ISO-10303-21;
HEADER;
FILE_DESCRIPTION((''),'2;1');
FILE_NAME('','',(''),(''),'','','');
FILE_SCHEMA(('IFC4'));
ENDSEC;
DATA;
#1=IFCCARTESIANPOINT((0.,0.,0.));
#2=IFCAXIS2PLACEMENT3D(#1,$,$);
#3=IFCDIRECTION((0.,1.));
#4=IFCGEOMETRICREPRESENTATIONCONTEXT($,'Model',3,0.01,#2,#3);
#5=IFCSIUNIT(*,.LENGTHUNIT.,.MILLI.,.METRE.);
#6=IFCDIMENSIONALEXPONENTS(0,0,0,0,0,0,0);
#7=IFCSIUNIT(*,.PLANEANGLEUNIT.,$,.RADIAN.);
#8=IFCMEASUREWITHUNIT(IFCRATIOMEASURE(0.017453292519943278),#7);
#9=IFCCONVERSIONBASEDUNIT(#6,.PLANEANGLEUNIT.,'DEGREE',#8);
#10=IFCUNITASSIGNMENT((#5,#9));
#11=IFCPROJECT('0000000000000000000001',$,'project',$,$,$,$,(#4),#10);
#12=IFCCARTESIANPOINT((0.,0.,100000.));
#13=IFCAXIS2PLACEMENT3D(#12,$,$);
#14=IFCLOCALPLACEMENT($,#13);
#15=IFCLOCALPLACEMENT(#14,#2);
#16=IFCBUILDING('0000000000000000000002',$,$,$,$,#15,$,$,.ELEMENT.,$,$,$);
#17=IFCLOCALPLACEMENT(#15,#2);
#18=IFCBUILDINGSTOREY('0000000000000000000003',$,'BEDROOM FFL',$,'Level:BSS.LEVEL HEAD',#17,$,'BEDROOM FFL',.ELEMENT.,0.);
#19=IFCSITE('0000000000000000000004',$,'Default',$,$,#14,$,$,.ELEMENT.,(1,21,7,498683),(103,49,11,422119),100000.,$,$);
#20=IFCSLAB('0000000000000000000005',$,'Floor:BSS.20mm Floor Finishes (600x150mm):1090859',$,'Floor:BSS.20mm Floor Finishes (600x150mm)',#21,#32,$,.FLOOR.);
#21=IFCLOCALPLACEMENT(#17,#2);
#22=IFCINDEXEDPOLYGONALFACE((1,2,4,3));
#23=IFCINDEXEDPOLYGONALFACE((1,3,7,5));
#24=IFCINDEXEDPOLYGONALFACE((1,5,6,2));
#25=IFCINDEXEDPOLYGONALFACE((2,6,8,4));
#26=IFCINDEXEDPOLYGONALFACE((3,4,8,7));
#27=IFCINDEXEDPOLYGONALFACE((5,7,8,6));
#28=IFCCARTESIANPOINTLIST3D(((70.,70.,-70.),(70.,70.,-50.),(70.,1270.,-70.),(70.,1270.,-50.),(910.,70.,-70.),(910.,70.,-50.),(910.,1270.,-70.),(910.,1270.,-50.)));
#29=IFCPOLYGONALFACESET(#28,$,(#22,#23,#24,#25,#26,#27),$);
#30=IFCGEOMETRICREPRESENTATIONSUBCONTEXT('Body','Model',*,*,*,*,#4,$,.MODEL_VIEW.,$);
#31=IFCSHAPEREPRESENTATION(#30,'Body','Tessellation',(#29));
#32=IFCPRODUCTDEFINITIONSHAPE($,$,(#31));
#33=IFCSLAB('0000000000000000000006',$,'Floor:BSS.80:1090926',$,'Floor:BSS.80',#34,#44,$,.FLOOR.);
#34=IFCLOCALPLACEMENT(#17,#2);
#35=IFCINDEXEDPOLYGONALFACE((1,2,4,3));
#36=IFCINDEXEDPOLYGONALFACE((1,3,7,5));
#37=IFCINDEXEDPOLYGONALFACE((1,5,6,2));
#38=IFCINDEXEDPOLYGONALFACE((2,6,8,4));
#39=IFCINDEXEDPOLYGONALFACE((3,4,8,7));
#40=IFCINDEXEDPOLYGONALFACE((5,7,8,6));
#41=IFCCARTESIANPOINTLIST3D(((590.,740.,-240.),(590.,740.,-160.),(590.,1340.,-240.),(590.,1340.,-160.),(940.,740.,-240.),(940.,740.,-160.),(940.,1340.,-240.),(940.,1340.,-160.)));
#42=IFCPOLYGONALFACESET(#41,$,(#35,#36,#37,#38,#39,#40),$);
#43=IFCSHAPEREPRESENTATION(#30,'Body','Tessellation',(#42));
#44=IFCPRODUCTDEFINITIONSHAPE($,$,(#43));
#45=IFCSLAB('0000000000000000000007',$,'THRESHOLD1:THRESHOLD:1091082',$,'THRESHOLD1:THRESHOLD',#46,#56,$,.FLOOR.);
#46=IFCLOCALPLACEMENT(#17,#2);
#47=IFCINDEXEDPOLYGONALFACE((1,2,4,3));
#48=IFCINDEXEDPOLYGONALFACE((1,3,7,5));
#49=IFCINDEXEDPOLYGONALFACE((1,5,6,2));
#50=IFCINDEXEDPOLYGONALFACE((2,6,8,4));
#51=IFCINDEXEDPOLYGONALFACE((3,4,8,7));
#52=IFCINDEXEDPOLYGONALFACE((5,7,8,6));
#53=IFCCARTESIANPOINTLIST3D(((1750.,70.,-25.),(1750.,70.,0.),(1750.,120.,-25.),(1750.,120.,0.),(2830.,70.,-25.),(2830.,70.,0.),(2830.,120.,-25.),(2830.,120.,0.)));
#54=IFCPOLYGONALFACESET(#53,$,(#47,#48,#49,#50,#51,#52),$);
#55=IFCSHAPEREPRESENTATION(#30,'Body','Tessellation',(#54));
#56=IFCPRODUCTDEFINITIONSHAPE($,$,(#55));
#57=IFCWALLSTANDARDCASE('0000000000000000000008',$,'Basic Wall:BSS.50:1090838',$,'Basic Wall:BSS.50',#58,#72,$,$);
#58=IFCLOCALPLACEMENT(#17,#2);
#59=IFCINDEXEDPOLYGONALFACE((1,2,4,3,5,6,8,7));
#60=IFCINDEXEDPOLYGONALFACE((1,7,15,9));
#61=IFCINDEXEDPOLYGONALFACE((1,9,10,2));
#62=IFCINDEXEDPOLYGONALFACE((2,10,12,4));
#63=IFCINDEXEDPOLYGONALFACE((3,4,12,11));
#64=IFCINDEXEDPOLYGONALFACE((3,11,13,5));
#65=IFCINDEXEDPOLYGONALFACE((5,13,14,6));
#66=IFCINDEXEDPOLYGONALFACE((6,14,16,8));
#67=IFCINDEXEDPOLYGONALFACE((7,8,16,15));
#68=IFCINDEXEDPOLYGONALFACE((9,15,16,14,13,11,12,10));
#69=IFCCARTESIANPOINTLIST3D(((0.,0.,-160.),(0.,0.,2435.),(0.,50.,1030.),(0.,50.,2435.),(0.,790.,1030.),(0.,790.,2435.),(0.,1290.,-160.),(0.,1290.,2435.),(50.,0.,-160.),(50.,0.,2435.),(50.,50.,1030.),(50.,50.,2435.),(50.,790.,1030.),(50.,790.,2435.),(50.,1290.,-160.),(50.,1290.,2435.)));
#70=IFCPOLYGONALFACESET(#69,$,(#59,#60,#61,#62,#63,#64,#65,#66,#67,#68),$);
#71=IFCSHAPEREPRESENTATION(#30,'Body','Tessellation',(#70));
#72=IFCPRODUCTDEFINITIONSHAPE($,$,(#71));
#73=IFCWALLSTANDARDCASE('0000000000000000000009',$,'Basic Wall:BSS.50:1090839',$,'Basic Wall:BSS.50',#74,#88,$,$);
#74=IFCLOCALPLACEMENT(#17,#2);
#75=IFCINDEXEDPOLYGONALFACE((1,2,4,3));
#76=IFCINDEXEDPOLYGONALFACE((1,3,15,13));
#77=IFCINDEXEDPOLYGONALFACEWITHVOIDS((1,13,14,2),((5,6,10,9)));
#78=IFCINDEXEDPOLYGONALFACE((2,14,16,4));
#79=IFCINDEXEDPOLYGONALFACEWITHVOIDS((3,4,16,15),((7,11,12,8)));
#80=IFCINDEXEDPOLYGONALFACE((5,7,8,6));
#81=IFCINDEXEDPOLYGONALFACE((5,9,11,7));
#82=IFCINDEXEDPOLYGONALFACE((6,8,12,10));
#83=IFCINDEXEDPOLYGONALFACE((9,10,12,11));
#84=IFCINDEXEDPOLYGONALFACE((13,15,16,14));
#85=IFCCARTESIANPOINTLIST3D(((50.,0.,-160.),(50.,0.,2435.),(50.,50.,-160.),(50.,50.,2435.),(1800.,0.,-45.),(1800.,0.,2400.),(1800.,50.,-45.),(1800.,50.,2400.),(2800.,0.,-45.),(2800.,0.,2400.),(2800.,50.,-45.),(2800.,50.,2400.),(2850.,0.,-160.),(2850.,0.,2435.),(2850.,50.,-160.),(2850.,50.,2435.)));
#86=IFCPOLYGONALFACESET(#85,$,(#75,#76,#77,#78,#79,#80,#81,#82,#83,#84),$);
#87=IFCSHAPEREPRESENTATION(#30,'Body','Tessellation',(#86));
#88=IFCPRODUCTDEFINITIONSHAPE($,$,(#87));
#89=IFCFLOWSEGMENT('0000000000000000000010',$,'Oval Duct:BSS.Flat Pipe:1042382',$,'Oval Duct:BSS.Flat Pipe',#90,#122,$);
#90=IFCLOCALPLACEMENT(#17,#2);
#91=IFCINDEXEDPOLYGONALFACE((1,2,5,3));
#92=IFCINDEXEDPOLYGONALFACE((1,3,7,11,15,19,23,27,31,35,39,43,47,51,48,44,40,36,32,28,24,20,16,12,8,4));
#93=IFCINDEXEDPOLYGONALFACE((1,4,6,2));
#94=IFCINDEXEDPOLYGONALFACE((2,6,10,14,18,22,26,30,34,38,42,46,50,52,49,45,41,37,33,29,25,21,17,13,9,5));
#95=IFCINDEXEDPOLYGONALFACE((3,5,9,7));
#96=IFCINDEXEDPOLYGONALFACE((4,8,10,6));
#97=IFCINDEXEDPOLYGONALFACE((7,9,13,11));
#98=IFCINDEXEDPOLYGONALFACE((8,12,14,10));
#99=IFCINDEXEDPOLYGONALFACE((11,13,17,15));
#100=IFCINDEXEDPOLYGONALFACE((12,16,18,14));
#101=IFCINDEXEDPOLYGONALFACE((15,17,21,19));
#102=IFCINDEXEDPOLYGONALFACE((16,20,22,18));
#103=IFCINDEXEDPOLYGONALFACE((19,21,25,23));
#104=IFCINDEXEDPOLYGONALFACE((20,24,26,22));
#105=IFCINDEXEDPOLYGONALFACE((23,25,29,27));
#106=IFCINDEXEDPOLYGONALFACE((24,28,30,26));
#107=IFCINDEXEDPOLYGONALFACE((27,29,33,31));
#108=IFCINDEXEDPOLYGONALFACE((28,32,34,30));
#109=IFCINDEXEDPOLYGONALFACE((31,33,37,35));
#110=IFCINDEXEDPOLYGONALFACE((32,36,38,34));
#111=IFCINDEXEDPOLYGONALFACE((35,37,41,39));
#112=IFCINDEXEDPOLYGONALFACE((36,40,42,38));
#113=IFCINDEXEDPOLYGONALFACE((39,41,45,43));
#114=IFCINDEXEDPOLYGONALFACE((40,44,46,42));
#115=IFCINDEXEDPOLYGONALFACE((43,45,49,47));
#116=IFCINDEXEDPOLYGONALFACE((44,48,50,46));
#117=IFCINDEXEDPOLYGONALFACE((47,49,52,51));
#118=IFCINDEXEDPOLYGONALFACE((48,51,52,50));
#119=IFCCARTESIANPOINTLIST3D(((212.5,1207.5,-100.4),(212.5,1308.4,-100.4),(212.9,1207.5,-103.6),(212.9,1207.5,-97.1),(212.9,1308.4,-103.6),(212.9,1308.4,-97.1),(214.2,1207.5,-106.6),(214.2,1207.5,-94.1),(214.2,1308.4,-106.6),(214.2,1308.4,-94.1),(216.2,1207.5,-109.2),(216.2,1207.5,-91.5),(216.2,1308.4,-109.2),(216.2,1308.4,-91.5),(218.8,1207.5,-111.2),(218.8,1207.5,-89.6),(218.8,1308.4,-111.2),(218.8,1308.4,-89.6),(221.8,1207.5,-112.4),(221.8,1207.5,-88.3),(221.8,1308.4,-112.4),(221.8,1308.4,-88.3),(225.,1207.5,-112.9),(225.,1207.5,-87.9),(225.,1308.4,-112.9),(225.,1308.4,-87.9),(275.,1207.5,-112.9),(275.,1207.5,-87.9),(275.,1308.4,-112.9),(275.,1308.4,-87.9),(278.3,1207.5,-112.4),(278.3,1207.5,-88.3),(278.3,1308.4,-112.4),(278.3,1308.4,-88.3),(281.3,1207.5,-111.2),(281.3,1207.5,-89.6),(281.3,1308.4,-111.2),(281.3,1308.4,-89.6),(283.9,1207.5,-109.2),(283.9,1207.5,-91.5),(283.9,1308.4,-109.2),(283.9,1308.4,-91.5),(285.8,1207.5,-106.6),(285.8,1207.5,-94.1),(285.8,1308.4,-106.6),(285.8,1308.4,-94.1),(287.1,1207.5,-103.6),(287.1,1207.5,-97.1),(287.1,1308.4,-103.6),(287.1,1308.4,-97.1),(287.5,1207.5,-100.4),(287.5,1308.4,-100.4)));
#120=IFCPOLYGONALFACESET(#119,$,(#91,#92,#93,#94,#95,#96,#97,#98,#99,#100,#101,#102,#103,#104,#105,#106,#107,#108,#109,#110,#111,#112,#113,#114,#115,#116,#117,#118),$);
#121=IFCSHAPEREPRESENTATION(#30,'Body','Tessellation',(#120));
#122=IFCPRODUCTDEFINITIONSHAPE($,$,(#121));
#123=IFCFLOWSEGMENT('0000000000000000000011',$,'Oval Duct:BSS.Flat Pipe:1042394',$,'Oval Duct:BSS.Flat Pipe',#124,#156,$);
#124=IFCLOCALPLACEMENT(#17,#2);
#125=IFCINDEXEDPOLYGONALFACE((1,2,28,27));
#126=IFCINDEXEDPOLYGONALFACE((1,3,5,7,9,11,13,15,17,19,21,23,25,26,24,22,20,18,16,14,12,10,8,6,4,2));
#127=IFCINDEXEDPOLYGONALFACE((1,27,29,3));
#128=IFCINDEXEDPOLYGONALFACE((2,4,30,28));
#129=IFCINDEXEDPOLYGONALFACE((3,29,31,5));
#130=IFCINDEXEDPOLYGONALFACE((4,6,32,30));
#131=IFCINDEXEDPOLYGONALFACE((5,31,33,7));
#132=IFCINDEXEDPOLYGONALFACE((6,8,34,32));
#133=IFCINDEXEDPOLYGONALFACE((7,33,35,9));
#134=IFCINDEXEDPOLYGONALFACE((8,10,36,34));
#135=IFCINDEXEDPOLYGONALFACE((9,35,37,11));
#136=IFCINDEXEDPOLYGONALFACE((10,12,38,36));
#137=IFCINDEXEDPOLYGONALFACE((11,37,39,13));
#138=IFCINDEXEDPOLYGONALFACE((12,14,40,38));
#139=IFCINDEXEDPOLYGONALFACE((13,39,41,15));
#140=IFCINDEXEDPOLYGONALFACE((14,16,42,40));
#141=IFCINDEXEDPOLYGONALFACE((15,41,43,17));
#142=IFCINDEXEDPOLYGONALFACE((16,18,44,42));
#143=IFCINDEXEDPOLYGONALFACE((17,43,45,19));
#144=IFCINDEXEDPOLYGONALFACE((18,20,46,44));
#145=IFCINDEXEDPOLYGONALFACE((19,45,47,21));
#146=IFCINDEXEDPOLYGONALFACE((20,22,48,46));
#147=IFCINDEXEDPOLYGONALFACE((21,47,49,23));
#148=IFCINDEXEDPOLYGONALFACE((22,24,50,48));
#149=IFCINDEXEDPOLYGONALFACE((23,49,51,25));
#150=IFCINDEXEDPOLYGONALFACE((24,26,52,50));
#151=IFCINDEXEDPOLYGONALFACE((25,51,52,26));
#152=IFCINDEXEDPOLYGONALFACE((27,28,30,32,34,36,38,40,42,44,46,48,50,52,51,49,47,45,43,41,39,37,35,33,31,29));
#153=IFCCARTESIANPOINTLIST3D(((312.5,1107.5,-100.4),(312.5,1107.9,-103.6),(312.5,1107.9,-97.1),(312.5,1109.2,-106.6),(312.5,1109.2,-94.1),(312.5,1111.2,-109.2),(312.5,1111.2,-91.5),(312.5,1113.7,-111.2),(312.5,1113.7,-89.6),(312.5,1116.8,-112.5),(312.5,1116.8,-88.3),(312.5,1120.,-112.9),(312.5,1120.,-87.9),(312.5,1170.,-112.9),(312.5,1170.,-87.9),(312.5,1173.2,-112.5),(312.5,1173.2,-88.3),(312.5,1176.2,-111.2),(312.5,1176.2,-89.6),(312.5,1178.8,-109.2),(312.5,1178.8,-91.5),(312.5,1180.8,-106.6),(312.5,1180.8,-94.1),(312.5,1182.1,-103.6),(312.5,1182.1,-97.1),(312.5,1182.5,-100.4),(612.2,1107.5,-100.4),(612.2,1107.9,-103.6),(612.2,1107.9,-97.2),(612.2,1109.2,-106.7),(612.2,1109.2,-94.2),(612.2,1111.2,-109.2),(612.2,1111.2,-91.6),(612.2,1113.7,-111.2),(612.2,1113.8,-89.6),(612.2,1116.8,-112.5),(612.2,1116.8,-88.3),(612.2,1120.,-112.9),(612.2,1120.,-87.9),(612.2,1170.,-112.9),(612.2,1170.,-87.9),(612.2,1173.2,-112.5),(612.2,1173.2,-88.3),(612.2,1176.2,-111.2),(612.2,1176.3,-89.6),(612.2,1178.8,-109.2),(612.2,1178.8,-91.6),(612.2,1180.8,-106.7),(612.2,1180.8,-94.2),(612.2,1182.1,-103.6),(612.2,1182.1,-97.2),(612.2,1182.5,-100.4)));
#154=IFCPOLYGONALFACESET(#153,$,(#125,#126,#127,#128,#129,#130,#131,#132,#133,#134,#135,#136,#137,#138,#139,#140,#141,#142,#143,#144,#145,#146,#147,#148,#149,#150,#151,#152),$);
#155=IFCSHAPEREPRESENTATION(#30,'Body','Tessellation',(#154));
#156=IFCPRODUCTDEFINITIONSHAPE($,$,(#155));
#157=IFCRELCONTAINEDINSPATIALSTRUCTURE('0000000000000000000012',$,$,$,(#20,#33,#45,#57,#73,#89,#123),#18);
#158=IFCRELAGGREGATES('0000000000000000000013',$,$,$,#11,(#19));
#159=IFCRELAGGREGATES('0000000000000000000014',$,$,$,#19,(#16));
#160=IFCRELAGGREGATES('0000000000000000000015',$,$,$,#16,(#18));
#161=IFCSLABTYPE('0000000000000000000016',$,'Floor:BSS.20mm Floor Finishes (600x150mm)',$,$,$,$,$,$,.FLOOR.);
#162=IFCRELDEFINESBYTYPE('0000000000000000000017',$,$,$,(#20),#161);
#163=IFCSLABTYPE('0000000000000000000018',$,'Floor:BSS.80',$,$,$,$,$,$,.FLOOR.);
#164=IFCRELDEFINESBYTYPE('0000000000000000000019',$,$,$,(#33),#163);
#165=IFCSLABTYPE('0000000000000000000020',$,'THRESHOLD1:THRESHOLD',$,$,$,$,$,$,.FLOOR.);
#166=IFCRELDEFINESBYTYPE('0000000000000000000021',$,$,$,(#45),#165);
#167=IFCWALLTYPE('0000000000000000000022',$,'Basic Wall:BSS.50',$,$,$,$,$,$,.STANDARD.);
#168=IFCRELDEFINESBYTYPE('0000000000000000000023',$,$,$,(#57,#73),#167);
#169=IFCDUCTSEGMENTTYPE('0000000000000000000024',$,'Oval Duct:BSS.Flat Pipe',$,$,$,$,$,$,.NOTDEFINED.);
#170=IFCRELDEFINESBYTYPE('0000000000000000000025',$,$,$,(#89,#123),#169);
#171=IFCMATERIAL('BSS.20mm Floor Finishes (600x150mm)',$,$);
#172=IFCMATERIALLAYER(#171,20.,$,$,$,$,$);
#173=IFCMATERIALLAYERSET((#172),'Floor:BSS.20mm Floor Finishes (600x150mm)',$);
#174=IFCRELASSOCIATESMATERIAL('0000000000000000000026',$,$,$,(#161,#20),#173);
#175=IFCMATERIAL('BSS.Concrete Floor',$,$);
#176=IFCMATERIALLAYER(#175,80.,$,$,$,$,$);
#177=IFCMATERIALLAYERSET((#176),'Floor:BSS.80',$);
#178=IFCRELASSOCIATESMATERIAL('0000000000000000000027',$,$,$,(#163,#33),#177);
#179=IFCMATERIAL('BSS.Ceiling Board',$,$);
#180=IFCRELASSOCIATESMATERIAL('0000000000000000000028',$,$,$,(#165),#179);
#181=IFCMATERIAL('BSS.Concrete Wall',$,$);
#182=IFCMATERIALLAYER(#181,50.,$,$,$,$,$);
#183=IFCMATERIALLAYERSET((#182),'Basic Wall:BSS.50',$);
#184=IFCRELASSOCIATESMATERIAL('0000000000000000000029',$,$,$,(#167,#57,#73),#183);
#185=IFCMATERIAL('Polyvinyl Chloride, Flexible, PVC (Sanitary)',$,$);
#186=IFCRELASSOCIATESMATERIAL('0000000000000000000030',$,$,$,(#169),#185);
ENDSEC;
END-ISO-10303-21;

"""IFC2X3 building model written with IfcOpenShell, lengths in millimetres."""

from ifc_helpers import new_model, entity, si_unit, converted_unit, direction, frame, frame_2d, origin, origin_2d_with_axis, place, context, subcontext, project, spatial, polyline, circle_curve, parameter, trimmed, segment, composite_curve, rectangle, outline, extrude, material, layer, layer_set, layer_usage, type_object, element, save


model = new_model("IFC2X3")

# Units and contexts
model_context = context("Model", 3, precision=0.01, world=origin(), true_north=direction((0.0, 1.0)))
body_context = subcontext(model_context, "Body", "Model", "MODEL_VIEW")
ifc_project = project(units=[si_unit("LENGTHUNIT", "METRE", prefix="MILLI"), converted_unit("PLANEANGLEUNIT", "DEGREE", entity("IfcRatioMeasure", 0.017453292519943278), si_unit("PLANEANGLEUNIT", "RADIAN"), dimensions=[0, 0, 0, 0, 0, 0, 0])], contexts=[model_context])

# Site, building, storey
site_placement = place(None, frame((0.0, 0.0, 100000.0)))
site = spatial("IfcSite", under=ifc_project, at=site_placement, Name="Default", CompositionType="ELEMENT", RefLatitude=(1, 21, 7, 498683), RefLongitude=(103, 49, 11, 422119), RefElevation=100000.0)
building_placement = place(site_placement, origin())
building = spatial("IfcBuilding", under=site, at=building_placement, CompositionType="ELEMENT")
storey_placement = place(building_placement, origin())
storey = spatial("IfcBuildingStorey", under=building, at=storey_placement, Name="BEDROOM FFL", ObjectType="Level:BSS.LEVEL HEAD", LongName="BEDROOM FFL", CompositionType="ELEMENT", Elevation=0.0)

# Slabs
ifc_material_1 = material(Name="BSS.Concrete Floor")
ifc_material_2 = material(Name="BSS.20mm Floor Finishes (600x150mm)")
ifc_layer_1 = layer(ifc_material_2, 20.0)
ifc_layer_set_1 = layer_set([ifc_layer_1], Name="Floor:BSS.20mm Floor Finishes (600x150mm)")
ifc_layer_usage_1 = layer_usage(ifc_layer_set_1, "AXIS3", "POSITIVE", 0.0)
slab_type_1 = type_object("IfcSlabType", Name="Floor:BSS.20mm Floor Finishes (600x150mm)", PredefinedType="FLOOR", material=ifc_layer_set_1)
slab_1_placement = place(storey_placement, origin())
element("IfcSlab", 1, at=slab_1_placement, inside=storey, type_object=slab_type_1, material=ifc_layer_usage_1, Name="Floor:BSS.20mm Floor Finishes (600x150mm):1090859", ObjectType="Floor:BSS.20mm Floor Finishes (600x150mm)", PredefinedType="FLOOR", context=body_context, shape_type="SweptSolid", body=[
    extrude(rectangle(XDim=1200.0, YDim=840.0, at=frame_2d((0.0, 0.0), x_axis=(1.0, 0.0))), frame((490.0, 670.0, -50.0), z_axis=(0.0, 0.0, -1.0), x_axis=(0.0, 1.0, 0.0)), (0.0, 0.0, 1.0), 20.0),
])
ifc_layer_2 = layer(ifc_material_1, 80.0)
ifc_layer_set_2 = layer_set([ifc_layer_2], Name="Floor:BSS.80")
ifc_layer_usage_2 = layer_usage(ifc_layer_set_2, "AXIS3", "POSITIVE", 0.0)
slab_type_2 = type_object("IfcSlabType", Name="Floor:BSS.80", PredefinedType="FLOOR", material=ifc_layer_set_2)
slab_2_placement = place(storey_placement, origin())
element("IfcSlab", 2, at=slab_2_placement, inside=storey, type_object=slab_type_2, material=ifc_layer_usage_2, Name="Floor:BSS.80:1090926", ObjectType="Floor:BSS.80", PredefinedType="FLOOR", context=body_context, shape_type="SweptSolid", body=[
    extrude(rectangle(XDim=600.0, YDim=350.0, at=frame_2d((0.0, 0.0), x_axis=(1.0, 0.0))), frame((765.0, 1040.0, -160.0), z_axis=(0.0, 0.0, -1.0), x_axis=(0.0, 1.0, 0.0)), (0.0, 0.0, 1.0), 80.0),
])
ifc_material_3 = material(Name="BSS.Ceiling Board")
slab_type_3 = type_object("IfcSlabType", Name="THRESHOLD1:THRESHOLD", PredefinedType="FLOOR", material=ifc_material_3)
slab_3_placement = place(storey_placement, origin())
element("IfcSlab", 3, at=slab_3_placement, inside=storey, type_object=slab_type_3, Name="THRESHOLD1:THRESHOLD:1091082", ObjectType="THRESHOLD1:THRESHOLD", PredefinedType="FLOOR", context=body_context, shape_type="SweptSolid", body=[
    extrude(rectangle(XDim=1080.0, YDim=50.0, at=frame_2d((0.0, 0.0), x_axis=(1.0, 0.0))), frame((2290.0, 95.0, -25.0)), (0.0, 0.0, 1.0), 25.0),
])

# Walls, openings
ifc_material_4 = material(Name="BSS.Concrete Wall")
ifc_layer_3 = layer(ifc_material_4, 50.0)
ifc_layer_set_3 = layer_set([ifc_layer_3], Name="Basic Wall:BSS.50")
ifc_layer_usage_3 = layer_usage(ifc_layer_set_3, "AXIS2", "NEGATIVE", 25.0)
wall_type = type_object("IfcWallType", Name="Basic Wall:BSS.50", PredefinedType="STANDARD", material=ifc_layer_set_3)
wall_1_placement = place(storey_placement, frame((25.0, 1290.0, -160.0), z_axis=(0.0, 0.0, 1.0), x_axis=(0.0, -1.0, 0.0)))
wall_1 = element("IfcWallStandardCase", 4, at=wall_1_placement, inside=storey, type_object=wall_type, material=ifc_layer_usage_3, Name="Basic Wall:BSS.50:1090838", ObjectType="Basic Wall:BSS.50", context=body_context, shape_type="SweptSolid", body=[
    extrude(rectangle(XDim=1290.0, YDim=50.0, at=frame_2d((645.0, 0.0), x_axis=(-1.0, 0.0))), origin(), (0.0, 0.0, 1.0), 2595.0),
])
opening_1_placement = place(wall_1_placement, frame((1290.0, -25.0, 160.0), z_axis=(0.0, 0.0, 1.0), x_axis=(0.0, 1.0, 0.0)))
element("IfcOpeningElement", 5, at=opening_1_placement, cuts=wall_1, ObjectType="Opening", context=body_context, shape_type="SweptSolid", body=[
    extrude(rectangle(XDim=1405.0, YDim=740.0, at=origin_2d_with_axis()), frame((-1474.0, 420.0, 1732.5), z_axis=(1.0, 0.0, 0.0), x_axis=(0.0, 0.0, -1.0)), (0.0, 0.0, 1.0), 3048.0),
])
ifc_layer_usage_4 = layer_usage(ifc_layer_set_3, "AXIS2", "POSITIVE", -25.0)
wall_2_placement = place(storey_placement, frame((50.0, 25.0, -160.0)))
wall_2 = element("IfcWallStandardCase", 6, at=wall_2_placement, inside=storey, type_object=wall_type, material=ifc_layer_usage_4, Name="Basic Wall:BSS.50:1090839", ObjectType="Basic Wall:BSS.50", context=body_context, shape_type="SweptSolid", body=[
    extrude(rectangle(XDim=2800.0, YDim=50.0, at=frame_2d((1400.0, 0.0), x_axis=(-1.0, 0.0))), origin(), (0.0, 0.0, 1.0), 2595.0),
])
opening_2_placement = place(wall_2_placement, frame((-50.0, -25.0, 160.0)))
element("IfcOpeningElement", 7, at=opening_2_placement, cuts=wall_2, ObjectType="Opening", context=body_context, shape_type="SweptSolid", body=[
    extrude(rectangle(XDim=2445.0, YDim=1000.0, at=frame_2d((0.0, 0.0), x_axis=(1.0, 0.0))), frame((2300.0, -1474.0, 1177.5), z_axis=(0.0, 1.0, 0.0), x_axis=(0.0, 0.0, -1.0)), (0.0, 0.0, 1.0), 3048.0),
])

# Flow segments
ifc_material_5 = material(Name="Polyvinyl Chloride, Flexible, PVC (Sanitary)")
duct_segment_type = type_object("IfcDuctSegmentType", Name="Oval Duct:BSS.Flat Pipe", PredefinedType="NOTDEFINED", material=ifc_material_5)
flow_segment_1_placement = place(storey_placement, origin())
element("IfcFlowSegment", 8, at=flow_segment_1_placement, inside=storey, type_object=duct_segment_type, Name="Oval Duct:BSS.Flat Pipe:1042382", ObjectType="Oval Duct:BSS.Flat Pipe", context=body_context, shape_type="SweptSolid", body=[
    extrude(outline(composite_curve([segment(polyline([(-25.0, -12.5), (25.0, -12.5)]), True, "CONTINUOUS"), segment(trimmed(circle_curve(frame_2d((25.0, 0.0), x_axis=(-1.0, 0.0)), 12.5), [parameter(90.0)], [parameter(180.0)], True, "PARAMETER"), True, "CONTINUOUS"), segment(trimmed(circle_curve(frame_2d((25.0, 0.0), x_axis=(-1.0, 0.0)), 12.5), [parameter(180.0)], [parameter(270.0)], True, "PARAMETER"), True, "CONTINUOUS"), segment(polyline([(25.0, 12.5), (-25.0, 12.5)]), True, "CONTINUOUS"), segment(trimmed(circle_curve(frame_2d((-25.0, 0.0), x_axis=(-1.0, 0.0)), 12.5), [parameter(270.0)], [parameter(0.0)], True, "PARAMETER"), True, "CONTINUOUS"), segment(trimmed(circle_curve(frame_2d((-25.0, 0.0), x_axis=(-1.0, 0.0)), 12.5), [parameter(0.0)], [parameter(90.0)], True, "PARAMETER"), True, "CONTINUOUS")], self_intersect=False)), frame((250.0, 1207.5, -100.4), z_axis=(0.0, 1.0, 0.0), x_axis=(1.0, 0.0, 0.0)), (0.0, 0.0, 1.0), 100.9),
])
flow_segment_2_placement = place(storey_placement, origin())
element("IfcFlowSegment", 9, at=flow_segment_2_placement, inside=storey, type_object=duct_segment_type, Name="Oval Duct:BSS.Flat Pipe:1042394", ObjectType="Oval Duct:BSS.Flat Pipe", context=body_context, shape_type="SweptSolid", body=[
    extrude(outline(composite_curve([segment(polyline([(-25.0, -12.5), (25.0, -12.5)]), True, "CONTINUOUS"), segment(trimmed(circle_curve(frame_2d((25.0, 0.0), x_axis=(-1.0, 0.0)), 12.5), [parameter(90.0)], [parameter(180.0)], True, "PARAMETER"), True, "CONTINUOUS"), segment(trimmed(circle_curve(frame_2d((25.0, 0.0), x_axis=(-1.0, 0.0)), 12.5), [parameter(180.0)], [parameter(270.0)], True, "PARAMETER"), True, "CONTINUOUS"), segment(polyline([(25.0, 12.5), (-25.0, 12.5)]), True, "CONTINUOUS"), segment(trimmed(circle_curve(frame_2d((-25.0, 0.0), x_axis=(-1.0, 0.0)), 12.5), [parameter(270.0)], [parameter(0.0)], True, "PARAMETER"), True, "CONTINUOUS"), segment(trimmed(circle_curve(frame_2d((-25.0, 0.0), x_axis=(-1.0, 0.0)), 12.5), [parameter(0.0)], [parameter(90.0)], True, "PARAMETER"), True, "CONTINUOUS")], self_intersect=False)), frame((312.5, 1145.0, -100.4), z_axis=(1.0, 0.000002, -0.000075), x_axis=(0.000002, -1.0, 0.0)), (0.0, 0.0, 1.0), 299.7),
])

save(model, "model.ifc")
